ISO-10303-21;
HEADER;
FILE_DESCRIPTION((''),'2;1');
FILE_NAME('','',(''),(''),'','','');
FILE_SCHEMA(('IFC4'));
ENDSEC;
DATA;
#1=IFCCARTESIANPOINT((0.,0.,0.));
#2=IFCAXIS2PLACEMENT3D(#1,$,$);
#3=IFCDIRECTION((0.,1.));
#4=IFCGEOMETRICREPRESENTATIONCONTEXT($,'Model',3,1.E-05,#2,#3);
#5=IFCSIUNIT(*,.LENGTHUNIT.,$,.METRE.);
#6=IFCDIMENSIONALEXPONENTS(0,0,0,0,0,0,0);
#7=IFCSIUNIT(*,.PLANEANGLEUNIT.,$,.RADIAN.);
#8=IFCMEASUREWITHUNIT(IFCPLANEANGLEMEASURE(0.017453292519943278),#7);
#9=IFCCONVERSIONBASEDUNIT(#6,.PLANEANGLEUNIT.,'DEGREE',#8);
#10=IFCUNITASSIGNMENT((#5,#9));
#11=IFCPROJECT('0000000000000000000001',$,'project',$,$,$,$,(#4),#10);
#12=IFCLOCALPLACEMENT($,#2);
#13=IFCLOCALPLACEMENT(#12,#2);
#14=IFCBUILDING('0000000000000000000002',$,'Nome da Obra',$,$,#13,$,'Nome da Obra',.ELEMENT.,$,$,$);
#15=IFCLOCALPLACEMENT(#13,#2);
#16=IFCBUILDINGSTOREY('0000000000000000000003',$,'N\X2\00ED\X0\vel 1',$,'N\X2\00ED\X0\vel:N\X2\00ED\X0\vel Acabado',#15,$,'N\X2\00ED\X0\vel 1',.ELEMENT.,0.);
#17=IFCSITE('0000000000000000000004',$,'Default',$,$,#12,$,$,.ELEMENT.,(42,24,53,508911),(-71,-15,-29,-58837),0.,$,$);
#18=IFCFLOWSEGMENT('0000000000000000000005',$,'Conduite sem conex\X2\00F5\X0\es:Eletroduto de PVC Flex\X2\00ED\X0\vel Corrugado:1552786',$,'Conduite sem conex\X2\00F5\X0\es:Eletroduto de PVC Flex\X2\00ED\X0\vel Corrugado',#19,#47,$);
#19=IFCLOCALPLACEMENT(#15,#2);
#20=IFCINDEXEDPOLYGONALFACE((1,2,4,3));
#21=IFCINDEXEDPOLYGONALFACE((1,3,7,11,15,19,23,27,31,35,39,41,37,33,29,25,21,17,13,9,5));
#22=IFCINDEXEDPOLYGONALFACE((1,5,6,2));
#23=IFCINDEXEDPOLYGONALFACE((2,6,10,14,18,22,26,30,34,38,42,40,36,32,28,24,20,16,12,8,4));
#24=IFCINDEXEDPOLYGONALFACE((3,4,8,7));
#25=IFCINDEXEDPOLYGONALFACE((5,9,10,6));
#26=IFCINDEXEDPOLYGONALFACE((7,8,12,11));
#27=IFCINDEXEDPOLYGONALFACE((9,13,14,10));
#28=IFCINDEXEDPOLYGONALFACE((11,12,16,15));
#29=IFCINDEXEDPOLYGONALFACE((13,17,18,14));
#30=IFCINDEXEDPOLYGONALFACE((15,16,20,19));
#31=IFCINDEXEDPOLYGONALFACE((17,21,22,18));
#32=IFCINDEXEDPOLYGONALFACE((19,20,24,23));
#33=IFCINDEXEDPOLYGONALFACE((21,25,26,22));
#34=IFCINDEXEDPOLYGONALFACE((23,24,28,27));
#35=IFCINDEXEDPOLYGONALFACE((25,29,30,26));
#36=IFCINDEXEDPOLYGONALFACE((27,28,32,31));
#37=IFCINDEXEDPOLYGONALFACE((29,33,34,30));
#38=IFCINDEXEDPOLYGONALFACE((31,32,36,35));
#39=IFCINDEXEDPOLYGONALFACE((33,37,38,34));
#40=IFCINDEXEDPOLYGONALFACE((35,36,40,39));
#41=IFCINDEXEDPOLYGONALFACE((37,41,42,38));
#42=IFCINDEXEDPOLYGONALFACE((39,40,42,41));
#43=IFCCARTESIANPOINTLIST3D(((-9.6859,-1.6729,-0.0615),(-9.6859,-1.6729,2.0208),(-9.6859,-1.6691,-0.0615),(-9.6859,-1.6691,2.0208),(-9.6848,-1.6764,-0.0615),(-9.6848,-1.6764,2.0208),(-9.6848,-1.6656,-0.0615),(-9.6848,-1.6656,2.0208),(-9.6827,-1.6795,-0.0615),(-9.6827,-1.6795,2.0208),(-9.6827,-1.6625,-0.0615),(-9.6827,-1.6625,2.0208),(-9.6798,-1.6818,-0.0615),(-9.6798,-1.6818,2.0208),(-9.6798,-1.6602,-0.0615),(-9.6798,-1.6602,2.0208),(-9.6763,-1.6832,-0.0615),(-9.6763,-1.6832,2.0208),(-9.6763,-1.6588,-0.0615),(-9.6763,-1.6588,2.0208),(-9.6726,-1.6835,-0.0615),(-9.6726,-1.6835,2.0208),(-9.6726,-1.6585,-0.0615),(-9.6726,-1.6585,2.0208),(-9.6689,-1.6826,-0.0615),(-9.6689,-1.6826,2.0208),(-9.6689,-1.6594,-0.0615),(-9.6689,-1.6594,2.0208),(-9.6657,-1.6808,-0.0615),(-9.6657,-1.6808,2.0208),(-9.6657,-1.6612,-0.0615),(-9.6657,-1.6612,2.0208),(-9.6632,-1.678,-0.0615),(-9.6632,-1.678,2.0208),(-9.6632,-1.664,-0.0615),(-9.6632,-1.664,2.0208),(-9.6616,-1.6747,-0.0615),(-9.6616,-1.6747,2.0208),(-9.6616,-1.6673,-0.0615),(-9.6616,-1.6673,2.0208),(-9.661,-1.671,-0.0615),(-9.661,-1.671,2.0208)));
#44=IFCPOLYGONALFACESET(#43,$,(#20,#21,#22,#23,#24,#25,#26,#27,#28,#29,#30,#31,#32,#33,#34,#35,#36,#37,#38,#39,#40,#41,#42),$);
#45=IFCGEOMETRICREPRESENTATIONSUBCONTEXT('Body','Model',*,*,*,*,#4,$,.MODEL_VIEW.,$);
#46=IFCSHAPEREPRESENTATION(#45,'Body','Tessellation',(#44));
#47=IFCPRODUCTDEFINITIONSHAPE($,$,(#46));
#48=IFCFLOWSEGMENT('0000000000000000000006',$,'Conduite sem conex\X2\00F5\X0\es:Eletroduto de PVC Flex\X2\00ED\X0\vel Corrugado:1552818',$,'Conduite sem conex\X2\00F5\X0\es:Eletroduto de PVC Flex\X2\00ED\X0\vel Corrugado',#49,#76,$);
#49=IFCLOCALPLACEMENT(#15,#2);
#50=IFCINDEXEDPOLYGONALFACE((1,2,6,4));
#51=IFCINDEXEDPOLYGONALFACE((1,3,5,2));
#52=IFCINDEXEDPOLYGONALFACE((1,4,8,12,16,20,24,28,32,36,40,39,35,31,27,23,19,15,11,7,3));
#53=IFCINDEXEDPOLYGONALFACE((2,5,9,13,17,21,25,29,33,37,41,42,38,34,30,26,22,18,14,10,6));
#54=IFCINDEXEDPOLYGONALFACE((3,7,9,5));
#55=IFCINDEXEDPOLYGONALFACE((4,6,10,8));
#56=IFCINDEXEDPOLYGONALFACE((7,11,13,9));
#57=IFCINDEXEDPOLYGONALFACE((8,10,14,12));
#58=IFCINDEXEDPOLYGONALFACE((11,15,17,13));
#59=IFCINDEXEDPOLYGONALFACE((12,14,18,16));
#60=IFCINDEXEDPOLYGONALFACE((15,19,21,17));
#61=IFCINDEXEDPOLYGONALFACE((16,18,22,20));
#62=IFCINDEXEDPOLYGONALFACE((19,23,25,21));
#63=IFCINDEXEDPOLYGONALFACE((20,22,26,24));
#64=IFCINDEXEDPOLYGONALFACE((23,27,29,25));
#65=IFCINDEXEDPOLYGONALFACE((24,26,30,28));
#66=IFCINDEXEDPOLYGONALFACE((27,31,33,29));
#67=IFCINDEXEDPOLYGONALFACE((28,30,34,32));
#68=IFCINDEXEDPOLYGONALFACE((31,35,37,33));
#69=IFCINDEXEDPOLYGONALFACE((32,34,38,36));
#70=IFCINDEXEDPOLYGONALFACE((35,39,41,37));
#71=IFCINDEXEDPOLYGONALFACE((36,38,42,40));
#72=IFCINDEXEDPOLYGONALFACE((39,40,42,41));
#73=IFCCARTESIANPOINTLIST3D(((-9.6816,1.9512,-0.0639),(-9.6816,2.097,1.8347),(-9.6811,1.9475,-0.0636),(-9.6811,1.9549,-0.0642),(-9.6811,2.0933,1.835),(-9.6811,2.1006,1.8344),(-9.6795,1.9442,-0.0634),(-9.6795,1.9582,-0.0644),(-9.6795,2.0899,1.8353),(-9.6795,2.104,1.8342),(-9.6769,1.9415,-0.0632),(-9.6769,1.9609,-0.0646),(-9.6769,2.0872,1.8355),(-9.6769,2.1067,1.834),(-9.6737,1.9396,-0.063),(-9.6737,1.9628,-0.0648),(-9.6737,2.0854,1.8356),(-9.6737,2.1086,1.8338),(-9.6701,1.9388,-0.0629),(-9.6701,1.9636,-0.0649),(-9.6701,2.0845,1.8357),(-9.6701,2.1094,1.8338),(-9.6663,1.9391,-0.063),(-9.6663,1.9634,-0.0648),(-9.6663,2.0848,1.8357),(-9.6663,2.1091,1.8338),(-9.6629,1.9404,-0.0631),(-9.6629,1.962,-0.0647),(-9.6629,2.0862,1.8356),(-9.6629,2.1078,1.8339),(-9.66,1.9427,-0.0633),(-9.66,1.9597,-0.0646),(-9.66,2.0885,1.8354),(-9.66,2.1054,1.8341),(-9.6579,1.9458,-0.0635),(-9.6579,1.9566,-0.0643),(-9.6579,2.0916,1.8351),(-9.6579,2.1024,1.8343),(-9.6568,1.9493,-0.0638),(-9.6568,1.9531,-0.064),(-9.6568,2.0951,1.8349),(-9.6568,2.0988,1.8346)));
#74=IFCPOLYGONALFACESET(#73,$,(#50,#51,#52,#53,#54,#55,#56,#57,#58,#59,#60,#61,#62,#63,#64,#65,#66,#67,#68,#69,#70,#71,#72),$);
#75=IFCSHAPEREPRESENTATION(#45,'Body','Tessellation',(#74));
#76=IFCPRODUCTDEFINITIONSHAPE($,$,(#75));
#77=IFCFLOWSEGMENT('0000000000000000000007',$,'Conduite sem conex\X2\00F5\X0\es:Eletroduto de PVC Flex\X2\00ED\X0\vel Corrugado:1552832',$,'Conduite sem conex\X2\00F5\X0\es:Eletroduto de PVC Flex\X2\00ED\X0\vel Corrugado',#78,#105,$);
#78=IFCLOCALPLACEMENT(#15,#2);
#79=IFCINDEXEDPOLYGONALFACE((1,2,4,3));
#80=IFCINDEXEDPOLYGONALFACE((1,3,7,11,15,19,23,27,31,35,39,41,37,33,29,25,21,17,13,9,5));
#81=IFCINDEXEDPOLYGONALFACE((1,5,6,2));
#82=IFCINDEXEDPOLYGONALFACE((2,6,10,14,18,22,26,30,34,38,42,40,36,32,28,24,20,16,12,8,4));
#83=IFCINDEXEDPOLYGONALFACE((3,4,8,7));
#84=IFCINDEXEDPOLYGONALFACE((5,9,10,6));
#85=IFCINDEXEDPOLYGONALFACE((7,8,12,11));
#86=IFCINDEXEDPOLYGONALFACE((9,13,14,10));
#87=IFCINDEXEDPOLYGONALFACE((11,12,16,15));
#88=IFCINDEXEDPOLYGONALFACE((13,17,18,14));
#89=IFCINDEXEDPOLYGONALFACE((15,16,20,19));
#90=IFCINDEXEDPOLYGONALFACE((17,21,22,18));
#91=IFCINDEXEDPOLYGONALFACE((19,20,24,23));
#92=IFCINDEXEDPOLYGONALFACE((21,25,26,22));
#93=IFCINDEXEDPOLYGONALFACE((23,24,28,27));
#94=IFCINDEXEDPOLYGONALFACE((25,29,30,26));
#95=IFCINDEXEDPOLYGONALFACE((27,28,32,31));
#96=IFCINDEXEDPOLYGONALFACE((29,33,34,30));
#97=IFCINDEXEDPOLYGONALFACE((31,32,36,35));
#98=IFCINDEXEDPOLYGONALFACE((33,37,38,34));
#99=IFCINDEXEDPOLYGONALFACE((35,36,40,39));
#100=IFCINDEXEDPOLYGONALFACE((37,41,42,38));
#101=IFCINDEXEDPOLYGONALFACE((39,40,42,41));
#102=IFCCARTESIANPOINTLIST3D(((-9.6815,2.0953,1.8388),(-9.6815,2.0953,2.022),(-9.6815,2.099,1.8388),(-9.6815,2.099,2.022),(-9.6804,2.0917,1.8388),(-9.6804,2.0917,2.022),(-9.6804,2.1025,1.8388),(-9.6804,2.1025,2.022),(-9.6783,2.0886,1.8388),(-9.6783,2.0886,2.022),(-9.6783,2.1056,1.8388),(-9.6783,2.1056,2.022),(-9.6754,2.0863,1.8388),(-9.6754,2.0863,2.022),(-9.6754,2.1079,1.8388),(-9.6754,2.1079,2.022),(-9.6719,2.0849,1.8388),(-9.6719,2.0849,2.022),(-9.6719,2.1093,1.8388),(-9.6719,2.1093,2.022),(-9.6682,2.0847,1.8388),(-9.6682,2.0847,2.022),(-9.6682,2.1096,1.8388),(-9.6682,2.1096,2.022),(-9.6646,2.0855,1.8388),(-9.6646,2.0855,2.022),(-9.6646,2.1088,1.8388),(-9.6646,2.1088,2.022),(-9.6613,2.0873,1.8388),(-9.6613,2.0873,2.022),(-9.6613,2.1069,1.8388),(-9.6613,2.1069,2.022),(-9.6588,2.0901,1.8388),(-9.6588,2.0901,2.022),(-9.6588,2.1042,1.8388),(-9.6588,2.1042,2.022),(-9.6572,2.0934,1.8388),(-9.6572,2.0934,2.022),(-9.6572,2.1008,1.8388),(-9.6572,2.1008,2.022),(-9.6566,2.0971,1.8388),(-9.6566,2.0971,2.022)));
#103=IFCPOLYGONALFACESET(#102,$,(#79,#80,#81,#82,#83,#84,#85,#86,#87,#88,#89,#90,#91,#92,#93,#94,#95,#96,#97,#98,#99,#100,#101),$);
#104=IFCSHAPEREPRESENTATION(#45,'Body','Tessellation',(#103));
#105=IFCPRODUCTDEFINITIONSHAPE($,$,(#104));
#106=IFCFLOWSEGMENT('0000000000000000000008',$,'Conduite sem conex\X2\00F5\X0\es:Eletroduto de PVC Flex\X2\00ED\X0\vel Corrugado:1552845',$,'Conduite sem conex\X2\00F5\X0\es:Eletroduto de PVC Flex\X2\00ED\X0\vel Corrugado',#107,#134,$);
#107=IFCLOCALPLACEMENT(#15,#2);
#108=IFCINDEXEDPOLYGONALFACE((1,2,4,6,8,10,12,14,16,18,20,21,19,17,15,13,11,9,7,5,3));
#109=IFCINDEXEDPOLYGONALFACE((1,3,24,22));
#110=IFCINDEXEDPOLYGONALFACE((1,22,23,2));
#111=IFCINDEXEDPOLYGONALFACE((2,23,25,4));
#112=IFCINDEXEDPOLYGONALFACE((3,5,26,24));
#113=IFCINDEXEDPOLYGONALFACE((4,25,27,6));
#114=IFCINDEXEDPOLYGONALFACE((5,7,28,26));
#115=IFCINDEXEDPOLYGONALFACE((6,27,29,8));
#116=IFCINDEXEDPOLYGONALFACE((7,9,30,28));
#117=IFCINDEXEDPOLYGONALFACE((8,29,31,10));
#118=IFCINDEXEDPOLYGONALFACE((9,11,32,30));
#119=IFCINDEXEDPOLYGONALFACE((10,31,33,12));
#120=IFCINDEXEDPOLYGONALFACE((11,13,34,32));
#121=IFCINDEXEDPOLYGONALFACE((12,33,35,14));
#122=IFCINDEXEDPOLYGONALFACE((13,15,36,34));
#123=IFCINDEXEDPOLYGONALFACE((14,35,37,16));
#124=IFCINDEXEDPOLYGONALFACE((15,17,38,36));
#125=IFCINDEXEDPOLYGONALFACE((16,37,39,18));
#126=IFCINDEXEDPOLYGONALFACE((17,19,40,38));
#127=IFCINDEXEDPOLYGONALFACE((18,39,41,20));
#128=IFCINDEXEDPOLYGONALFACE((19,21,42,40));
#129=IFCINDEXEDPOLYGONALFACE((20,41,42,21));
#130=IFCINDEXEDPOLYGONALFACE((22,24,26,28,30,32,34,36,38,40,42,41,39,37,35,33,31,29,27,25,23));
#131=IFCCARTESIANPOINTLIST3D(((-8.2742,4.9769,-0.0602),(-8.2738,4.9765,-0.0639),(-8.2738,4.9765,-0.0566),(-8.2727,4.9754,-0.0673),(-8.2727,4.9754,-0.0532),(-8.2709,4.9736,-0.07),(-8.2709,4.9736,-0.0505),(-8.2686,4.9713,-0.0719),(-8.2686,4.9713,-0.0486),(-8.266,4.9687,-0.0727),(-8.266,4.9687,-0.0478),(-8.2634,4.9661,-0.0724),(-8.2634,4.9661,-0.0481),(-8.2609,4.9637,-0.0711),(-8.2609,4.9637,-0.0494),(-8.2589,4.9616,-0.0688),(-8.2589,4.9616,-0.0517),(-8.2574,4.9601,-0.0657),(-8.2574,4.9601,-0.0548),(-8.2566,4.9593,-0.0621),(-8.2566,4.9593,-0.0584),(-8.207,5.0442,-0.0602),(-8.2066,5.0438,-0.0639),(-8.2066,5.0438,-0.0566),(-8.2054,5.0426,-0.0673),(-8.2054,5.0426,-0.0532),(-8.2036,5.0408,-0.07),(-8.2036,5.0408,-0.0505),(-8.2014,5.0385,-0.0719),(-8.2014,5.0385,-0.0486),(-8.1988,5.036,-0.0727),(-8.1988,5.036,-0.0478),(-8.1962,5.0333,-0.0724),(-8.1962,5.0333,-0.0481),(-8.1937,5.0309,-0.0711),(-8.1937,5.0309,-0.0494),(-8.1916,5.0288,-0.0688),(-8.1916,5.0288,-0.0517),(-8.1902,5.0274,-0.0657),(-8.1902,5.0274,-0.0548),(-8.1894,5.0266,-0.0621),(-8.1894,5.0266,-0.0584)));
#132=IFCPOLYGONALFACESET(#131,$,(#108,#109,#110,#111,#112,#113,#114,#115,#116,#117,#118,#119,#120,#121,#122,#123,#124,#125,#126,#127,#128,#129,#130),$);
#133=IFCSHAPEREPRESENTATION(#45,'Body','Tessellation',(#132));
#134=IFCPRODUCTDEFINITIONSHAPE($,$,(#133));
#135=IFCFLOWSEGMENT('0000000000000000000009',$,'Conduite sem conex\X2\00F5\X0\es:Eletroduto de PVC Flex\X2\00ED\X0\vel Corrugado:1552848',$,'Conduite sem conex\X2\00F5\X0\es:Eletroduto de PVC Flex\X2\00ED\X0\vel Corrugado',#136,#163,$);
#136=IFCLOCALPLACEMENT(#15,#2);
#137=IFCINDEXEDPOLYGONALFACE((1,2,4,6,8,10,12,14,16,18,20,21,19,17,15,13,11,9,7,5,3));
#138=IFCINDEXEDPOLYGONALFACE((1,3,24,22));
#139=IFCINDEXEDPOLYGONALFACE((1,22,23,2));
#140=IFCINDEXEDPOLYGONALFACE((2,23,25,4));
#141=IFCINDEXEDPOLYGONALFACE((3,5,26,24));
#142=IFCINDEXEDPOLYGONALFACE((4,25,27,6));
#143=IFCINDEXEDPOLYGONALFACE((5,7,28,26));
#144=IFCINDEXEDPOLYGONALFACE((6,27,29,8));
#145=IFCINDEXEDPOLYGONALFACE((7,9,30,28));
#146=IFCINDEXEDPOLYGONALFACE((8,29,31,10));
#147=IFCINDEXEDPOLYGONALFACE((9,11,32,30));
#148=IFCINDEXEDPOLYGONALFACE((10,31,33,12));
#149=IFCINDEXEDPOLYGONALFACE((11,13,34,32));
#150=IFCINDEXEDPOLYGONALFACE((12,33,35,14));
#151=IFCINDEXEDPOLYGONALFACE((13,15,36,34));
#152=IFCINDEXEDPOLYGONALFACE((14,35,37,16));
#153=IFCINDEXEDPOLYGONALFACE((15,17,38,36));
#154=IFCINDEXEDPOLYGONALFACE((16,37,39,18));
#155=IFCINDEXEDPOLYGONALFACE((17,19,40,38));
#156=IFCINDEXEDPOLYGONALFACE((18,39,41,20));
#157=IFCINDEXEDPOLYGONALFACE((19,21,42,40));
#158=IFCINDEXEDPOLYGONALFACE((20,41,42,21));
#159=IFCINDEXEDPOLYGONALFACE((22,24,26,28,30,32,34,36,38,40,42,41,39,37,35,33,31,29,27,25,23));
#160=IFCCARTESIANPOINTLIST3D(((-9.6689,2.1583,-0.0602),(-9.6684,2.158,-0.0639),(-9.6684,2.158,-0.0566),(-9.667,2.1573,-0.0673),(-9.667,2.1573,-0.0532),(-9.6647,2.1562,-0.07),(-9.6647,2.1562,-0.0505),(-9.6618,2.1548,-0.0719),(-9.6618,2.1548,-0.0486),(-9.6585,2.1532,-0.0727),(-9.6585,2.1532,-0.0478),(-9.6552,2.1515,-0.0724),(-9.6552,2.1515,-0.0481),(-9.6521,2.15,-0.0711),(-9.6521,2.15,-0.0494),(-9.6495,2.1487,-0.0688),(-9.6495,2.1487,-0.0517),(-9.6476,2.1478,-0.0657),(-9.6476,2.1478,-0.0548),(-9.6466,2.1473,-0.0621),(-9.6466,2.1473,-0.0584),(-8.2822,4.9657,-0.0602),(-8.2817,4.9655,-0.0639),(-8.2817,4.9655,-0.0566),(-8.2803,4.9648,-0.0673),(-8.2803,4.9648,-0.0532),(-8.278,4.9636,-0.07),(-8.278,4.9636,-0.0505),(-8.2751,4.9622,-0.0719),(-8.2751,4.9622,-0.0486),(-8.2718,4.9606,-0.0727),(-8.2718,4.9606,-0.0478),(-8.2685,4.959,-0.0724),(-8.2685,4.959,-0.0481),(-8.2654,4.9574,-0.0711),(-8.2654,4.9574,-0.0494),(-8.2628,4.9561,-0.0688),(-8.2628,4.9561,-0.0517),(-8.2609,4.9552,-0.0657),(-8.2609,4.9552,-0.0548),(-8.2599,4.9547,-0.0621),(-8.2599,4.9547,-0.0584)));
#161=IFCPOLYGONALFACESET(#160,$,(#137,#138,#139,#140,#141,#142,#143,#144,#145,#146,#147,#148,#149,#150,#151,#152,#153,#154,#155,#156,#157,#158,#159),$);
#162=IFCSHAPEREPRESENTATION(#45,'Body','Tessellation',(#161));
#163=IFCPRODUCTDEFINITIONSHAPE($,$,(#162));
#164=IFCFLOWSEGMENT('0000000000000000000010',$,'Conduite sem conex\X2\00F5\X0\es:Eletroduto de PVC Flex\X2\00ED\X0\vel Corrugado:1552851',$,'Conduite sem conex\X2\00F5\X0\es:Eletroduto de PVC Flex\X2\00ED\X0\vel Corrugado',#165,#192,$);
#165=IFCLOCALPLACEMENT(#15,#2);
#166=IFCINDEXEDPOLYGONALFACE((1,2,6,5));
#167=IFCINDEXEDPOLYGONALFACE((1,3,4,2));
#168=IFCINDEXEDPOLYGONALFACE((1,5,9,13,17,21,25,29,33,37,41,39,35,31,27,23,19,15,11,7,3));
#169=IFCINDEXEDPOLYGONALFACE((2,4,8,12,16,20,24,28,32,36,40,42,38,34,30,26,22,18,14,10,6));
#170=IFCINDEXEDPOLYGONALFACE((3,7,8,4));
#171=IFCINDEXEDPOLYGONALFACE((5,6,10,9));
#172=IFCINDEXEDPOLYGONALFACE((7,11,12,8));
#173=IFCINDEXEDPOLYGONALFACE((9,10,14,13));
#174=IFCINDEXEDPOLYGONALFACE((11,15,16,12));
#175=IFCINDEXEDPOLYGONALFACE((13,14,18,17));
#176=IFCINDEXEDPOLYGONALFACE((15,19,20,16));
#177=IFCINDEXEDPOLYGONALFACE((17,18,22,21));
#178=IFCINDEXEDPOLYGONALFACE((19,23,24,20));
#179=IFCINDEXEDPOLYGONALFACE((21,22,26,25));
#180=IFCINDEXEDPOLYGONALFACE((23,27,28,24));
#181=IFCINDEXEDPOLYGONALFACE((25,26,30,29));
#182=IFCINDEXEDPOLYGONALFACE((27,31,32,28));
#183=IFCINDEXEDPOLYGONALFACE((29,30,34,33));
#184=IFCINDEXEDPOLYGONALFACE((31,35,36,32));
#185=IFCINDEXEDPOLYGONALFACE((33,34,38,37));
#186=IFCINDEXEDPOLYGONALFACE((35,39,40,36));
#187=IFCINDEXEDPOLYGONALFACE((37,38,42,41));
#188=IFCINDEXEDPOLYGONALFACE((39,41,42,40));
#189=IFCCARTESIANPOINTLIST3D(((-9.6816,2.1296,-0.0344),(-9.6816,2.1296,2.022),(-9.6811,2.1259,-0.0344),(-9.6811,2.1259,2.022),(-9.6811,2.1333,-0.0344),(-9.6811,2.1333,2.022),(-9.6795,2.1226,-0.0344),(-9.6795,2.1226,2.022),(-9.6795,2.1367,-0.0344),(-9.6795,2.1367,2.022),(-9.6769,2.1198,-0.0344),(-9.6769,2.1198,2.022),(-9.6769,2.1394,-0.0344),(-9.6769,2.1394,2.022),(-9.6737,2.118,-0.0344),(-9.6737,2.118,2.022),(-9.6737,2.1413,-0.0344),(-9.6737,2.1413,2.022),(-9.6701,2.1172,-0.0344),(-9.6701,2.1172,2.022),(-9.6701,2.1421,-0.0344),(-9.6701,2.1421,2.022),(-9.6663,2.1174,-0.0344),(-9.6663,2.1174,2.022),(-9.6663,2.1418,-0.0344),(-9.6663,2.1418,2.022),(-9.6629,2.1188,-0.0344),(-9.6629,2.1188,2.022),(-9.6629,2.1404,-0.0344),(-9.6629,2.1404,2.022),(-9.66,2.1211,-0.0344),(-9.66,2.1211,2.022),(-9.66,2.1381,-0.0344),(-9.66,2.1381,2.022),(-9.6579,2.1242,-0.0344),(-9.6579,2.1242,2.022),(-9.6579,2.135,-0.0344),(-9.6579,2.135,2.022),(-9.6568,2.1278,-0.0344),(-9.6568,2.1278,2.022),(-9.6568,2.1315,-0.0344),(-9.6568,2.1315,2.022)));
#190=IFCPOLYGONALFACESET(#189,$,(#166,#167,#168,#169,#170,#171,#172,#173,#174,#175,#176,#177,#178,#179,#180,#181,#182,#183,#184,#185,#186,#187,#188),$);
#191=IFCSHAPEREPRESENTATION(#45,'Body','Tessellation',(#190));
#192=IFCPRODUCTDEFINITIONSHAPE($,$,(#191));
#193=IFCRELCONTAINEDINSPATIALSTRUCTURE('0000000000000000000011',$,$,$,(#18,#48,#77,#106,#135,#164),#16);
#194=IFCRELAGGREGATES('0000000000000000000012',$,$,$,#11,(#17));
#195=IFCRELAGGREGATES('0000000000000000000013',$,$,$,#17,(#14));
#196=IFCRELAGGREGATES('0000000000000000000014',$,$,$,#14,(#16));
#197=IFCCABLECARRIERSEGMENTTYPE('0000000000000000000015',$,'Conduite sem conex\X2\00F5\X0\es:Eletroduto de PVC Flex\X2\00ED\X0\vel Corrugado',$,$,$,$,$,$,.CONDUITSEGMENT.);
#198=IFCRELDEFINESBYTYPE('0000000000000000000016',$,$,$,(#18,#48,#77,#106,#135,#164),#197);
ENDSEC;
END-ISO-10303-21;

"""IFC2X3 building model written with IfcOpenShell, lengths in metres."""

from ifc_helpers import new_model, entity, si_unit, converted_unit, direction, frame, frame_2d, origin, origin_2d_with_axis, place, context, subcontext, project, spatial, circle, extrude, type_object, element, save


model = new_model("IFC2X3")

# Units and contexts
model_context = context("Model", 3, precision=1e-05, world=origin(), true_north=direction((0.0, 1.0)))
body_context = subcontext(model_context, "Body", "Model", "MODEL_VIEW")
ifc_project = project(units=[si_unit("LENGTHUNIT", "METRE"), converted_unit("PLANEANGLEUNIT", "DEGREE", entity("IfcPlaneAngleMeasure", 0.017453292519943278), si_unit("PLANEANGLEUNIT", "RADIAN"), dimensions=[0, 0, 0, 0, 0, 0, 0])], contexts=[model_context])

# Site, building, storey
site_placement = place(None, origin())
site = spatial("IfcSite", under=ifc_project, at=site_placement, Name="Default", CompositionType="ELEMENT", RefLatitude=(42, 24, 53, 508911), RefLongitude=(-71, -15, -29, -58837), RefElevation=0.0)
building_placement = place(site_placement, origin())
building = spatial("IfcBuilding", under=site, at=building_placement, Name="Nome da Obra", LongName="Nome da Obra", CompositionType="ELEMENT")
storey_placement = place(building_placement, origin())
storey = spatial("IfcBuildingStorey", under=building, at=storey_placement, Name="Nível 1", ObjectType="Nível:Nível Acabado", LongName="Nível 1", CompositionType="ELEMENT", Elevation=0.0)

# Flow segments
cable_carrier_segment_type = type_object("IfcCableCarrierSegmentType", Name="Conduite sem conexões:Eletroduto de PVC Flexível Corrugado", PredefinedType="CONDUITSEGMENT")
flow_segment_1_placement = place(storey_placement, origin())
element("IfcFlowSegment", 1, at=flow_segment_1_placement, inside=storey, type_object=cable_carrier_segment_type, Name="Conduite sem conexões:Eletroduto de PVC Flexível Corrugado:1552786", ObjectType="Conduite sem conexões:Eletroduto de PVC Flexível Corrugado", context=body_context, shape_type="SweptSolid", body=[
    extrude(circle(Radius=0.0125, at=origin_2d_with_axis()), frame((-9.6735, -1.671, -0.0615)), (0.0, 0.0, 1.0), 2.0822),
])
flow_segment_2_placement = place(storey_placement, origin())
element("IfcFlowSegment", 2, at=flow_segment_2_placement, inside=storey, type_object=cable_carrier_segment_type, Name="Conduite sem conexões:Eletroduto de PVC Flexível Corrugado:1552818", ObjectType="Conduite sem conexões:Eletroduto de PVC Flexível Corrugado", context=body_context, shape_type="SweptSolid", body=[
    extrude(circle(Radius=0.0125, at=frame_2d((0.0, 0.0), x_axis=(1.0, 0.0))), frame((-9.6691, 1.9512, -0.0639), z_axis=(0.0, 0.076546, 0.997066), x_axis=(-1.0, 0.0, 0.0)), (0.0, 0.0, 1.0), 1.9042),
])
flow_segment_3_placement = place(storey_placement, origin())
element("IfcFlowSegment", 3, at=flow_segment_3_placement, inside=storey, type_object=cable_carrier_segment_type, Name="Conduite sem conexões:Eletroduto de PVC Flexível Corrugado:1552832", ObjectType="Conduite sem conexões:Eletroduto de PVC Flexível Corrugado", context=body_context, shape_type="SweptSolid", body=[
    extrude(circle(Radius=0.0125, at=frame_2d((0.0, 0.0), x_axis=(1.0, 0.0))), frame((-9.6691, 2.0971, 1.8388)), (0.0, 0.0, 1.0), 0.1832),
])
flow_segment_4_placement = place(storey_placement, origin())
element("IfcFlowSegment", 4, at=flow_segment_4_placement, inside=storey, type_object=cable_carrier_segment_type, Name="Conduite sem conexões:Eletroduto de PVC Flexível Corrugado:1552845", ObjectType="Conduite sem conexões:Eletroduto de PVC Flexível Corrugado", context=body_context, shape_type="SweptSolid", body=[
    extrude(circle(Radius=0.0125, at=frame_2d((0.0, 0.0), x_axis=(1.0, 0.0))), frame((-8.2654, 4.9681, -0.0602), z_axis=(0.707107, 0.707107, 0.0), x_axis=(-0.707107, 0.707107, 0.0)), (0.0, 0.0, 1.0), 0.0951),
])
flow_segment_5_placement = place(storey_placement, origin())
element("IfcFlowSegment", 5, at=flow_segment_5_placement, inside=storey, type_object=cable_carrier_segment_type, Name="Conduite sem conexões:Eletroduto de PVC Flexível Corrugado:1552848", ObjectType="Conduite sem conexões:Eletroduto de PVC Flexível Corrugado", context=body_context, shape_type="SweptSolid", body=[
    extrude(circle(Radius=0.0125, at=frame_2d((0.0, 0.0), x_axis=(1.0, 0.0))), frame((-9.6577, 2.1528, -0.0602), z_axis=(0.442858, 0.896592, 0.0), x_axis=(-0.896592, 0.442858, 0.0)), (0.0, 0.0, 1.0), 3.1312),
])
flow_segment_6_placement = place(storey_placement, origin())
element("IfcFlowSegment", 6, at=flow_segment_6_placement, inside=storey, type_object=cable_carrier_segment_type, Name="Conduite sem conexões:Eletroduto de PVC Flexível Corrugado:1552851", ObjectType="Conduite sem conexões:Eletroduto de PVC Flexível Corrugado", context=body_context, shape_type="SweptSolid", body=[
    extrude(circle(Radius=0.0125, at=frame_2d((0.0, 0.0), x_axis=(1.0, 0.0))), frame((-9.6691, 2.1296, -0.0344), z_axis=(0.0, 0.0, 1.0), x_axis=(-1.0, 0.0, 0.0)), (0.0, 0.0, 1.0), 2.0564),
])

save(model, "model.ifc")
